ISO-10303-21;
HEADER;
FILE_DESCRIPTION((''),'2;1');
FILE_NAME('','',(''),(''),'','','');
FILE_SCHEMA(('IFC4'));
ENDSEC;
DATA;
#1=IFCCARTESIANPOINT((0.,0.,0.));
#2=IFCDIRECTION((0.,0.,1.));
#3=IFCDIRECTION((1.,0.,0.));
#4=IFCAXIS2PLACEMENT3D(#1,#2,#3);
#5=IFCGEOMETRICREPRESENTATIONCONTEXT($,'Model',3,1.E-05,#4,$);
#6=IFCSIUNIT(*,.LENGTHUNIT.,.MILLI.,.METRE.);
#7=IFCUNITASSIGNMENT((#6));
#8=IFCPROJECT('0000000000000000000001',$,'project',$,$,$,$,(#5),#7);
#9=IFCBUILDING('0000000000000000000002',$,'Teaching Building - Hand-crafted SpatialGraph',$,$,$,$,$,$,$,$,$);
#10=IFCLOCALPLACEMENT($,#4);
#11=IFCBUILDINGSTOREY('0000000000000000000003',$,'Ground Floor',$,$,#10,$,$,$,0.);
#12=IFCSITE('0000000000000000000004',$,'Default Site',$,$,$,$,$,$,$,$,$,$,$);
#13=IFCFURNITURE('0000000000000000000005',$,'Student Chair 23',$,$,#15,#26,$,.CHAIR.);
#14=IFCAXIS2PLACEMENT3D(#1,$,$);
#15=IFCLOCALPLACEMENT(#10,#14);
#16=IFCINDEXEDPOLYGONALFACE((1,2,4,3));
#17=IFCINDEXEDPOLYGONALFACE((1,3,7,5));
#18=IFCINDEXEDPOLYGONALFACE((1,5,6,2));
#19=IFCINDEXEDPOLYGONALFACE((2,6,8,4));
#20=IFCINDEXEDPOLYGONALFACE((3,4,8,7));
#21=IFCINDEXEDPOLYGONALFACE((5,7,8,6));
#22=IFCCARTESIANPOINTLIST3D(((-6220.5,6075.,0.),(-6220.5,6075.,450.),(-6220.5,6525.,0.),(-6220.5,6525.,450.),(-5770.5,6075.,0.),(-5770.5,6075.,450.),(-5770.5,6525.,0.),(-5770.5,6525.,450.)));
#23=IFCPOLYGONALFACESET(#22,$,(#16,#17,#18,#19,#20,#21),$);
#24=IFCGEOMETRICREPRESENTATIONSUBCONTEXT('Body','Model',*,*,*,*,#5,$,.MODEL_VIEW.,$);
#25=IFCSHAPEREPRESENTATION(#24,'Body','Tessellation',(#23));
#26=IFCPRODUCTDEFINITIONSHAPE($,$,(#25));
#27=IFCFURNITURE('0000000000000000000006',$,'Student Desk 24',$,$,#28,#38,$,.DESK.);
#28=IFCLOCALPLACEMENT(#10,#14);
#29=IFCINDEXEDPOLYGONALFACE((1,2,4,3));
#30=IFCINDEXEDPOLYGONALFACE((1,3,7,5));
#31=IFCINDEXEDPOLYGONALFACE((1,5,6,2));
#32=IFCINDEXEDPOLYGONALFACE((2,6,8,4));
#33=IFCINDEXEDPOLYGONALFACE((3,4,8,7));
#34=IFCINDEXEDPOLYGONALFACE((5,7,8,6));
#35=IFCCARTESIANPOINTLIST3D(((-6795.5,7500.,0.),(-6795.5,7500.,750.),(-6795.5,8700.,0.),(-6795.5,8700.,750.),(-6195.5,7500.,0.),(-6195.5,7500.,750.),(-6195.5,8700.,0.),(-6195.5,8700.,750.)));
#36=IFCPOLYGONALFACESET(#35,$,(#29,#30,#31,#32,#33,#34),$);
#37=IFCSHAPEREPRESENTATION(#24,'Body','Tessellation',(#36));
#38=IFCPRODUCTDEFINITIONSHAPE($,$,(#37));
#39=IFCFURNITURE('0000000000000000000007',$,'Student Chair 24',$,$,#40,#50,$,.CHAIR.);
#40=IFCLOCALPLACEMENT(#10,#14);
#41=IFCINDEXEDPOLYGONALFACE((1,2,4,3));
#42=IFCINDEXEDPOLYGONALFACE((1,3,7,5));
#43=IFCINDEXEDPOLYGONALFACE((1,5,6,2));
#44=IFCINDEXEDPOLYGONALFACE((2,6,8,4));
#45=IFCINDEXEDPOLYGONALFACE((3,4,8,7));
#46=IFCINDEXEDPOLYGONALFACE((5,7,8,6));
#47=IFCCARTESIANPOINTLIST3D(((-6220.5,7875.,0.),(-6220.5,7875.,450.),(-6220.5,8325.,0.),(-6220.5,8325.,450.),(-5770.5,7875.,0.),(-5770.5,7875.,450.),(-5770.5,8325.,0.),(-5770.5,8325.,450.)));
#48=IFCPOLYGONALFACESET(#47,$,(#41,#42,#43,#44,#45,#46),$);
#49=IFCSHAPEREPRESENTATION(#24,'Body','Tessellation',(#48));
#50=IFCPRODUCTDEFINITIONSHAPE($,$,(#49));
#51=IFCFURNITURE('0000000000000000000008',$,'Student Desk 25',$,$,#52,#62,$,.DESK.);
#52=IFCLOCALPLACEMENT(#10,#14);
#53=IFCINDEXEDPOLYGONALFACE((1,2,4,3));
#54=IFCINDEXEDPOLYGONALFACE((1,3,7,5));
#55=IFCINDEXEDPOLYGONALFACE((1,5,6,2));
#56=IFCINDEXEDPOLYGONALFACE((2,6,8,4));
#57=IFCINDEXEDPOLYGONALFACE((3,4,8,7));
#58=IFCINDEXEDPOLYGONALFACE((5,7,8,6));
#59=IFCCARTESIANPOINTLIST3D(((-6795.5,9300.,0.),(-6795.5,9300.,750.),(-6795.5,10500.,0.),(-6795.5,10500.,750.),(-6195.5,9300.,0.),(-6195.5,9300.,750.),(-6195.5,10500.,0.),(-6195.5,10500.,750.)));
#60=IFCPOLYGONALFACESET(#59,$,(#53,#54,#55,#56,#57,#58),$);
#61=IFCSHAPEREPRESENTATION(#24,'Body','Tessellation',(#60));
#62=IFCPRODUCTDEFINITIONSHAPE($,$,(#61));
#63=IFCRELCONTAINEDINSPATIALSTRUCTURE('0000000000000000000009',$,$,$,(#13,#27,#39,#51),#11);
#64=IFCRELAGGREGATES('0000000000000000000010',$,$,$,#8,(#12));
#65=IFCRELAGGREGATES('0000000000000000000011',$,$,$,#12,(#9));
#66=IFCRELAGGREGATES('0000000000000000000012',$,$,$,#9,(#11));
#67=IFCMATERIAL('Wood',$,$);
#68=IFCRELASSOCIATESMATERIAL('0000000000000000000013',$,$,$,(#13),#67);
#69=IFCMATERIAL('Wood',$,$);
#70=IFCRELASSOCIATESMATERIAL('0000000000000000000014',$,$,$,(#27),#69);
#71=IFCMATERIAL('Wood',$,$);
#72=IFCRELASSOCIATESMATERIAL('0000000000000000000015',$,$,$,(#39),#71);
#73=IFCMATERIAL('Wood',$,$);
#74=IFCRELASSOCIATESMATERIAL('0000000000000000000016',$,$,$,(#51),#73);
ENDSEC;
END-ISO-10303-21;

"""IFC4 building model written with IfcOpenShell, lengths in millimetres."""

from ifc_helpers import new_model, si_unit, frame, origin_with_axes, origin_2d, place, context, subcontext, project, spatial, rectangle, extrude, material, element, save


model = new_model("IFC4")

# Units and contexts
model_context = context("Model", 3, precision=1e-05, world=origin_with_axes())
body_context = subcontext(model_context, "Body", "Model", "MODEL_VIEW")
ifc_project = project(units=[si_unit("LENGTHUNIT", "METRE", prefix="MILLI")], contexts=[model_context])

# Site, building, storey
site = spatial("IfcSite", under=ifc_project, Name="Default Site")
building = spatial("IfcBuilding", under=site, Name="Teaching Building - Hand-crafted SpatialGraph")
storey_placement = place(None, origin_with_axes())
storey = spatial("IfcBuildingStorey", under=building, at=storey_placement, Name="Ground Floor", Elevation=0.0)

# Furniture
ifc_material_1 = material(Name="Wood")
furniture_1_placement = place(storey_placement, frame((-5995.5, 6300.0, 0.0), z_axis=(0.0, 0.0, 1.0), x_axis=(1.0, 0.0, 0.0)))
element("IfcFurniture", 1, at=furniture_1_placement, inside=storey, material=ifc_material_1, Name="Student Chair 23", PredefinedType="CHAIR", context=body_context, shape_type="SweptSolid", body=[
    extrude(rectangle(XDim=450.0, YDim=450.0, at=origin_2d()), origin_with_axes(), (0.0, 0.0, 1.0), 450.0),
])
ifc_material_2 = material(Name="Wood")
furniture_2_placement = place(storey_placement, frame((-6495.5, 8100.0, 0.0), z_axis=(0.0, 0.0, 1.0), x_axis=(0.0, 1.0, 0.0)))
element("IfcFurniture", 2, at=furniture_2_placement, inside=storey, material=ifc_material_2, Name="Student Desk 24", PredefinedType="DESK", context=body_context, shape_type="SweptSolid", body=[
    extrude(rectangle(XDim=1200.0, YDim=600.0, at=origin_2d()), origin_with_axes(), (0.0, 0.0, 1.0), 750.0),
])
ifc_material_3 = material(Name="Wood")
furniture_3_placement = place(storey_placement, frame((-5995.5, 8100.0, 0.0), z_axis=(0.0, 0.0, 1.0), x_axis=(1.0, 0.0, 0.0)))
element("IfcFurniture", 3, at=furniture_3_placement, inside=storey, material=ifc_material_3, Name="Student Chair 24", PredefinedType="CHAIR", context=body_context, shape_type="SweptSolid", body=[
    extrude(rectangle(XDim=450.0, YDim=450.0, at=origin_2d()), origin_with_axes(), (0.0, 0.0, 1.0), 450.0),
])
ifc_material_4 = material(Name="Wood")
furniture_4_placement = place(storey_placement, frame((-6495.5, 9900.0, 0.0), z_axis=(0.0, 0.0, 1.0), x_axis=(0.0, 1.0, 0.0)))
element("IfcFurniture", 4, at=furniture_4_placement, inside=storey, material=ifc_material_4, Name="Student Desk 25", PredefinedType="DESK", context=body_context, shape_type="SweptSolid", body=[
    extrude(rectangle(XDim=1200.0, YDim=600.0, at=origin_2d()), origin_with_axes(), (0.0, 0.0, 1.0), 750.0),
])

save(model, "model.ifc")
